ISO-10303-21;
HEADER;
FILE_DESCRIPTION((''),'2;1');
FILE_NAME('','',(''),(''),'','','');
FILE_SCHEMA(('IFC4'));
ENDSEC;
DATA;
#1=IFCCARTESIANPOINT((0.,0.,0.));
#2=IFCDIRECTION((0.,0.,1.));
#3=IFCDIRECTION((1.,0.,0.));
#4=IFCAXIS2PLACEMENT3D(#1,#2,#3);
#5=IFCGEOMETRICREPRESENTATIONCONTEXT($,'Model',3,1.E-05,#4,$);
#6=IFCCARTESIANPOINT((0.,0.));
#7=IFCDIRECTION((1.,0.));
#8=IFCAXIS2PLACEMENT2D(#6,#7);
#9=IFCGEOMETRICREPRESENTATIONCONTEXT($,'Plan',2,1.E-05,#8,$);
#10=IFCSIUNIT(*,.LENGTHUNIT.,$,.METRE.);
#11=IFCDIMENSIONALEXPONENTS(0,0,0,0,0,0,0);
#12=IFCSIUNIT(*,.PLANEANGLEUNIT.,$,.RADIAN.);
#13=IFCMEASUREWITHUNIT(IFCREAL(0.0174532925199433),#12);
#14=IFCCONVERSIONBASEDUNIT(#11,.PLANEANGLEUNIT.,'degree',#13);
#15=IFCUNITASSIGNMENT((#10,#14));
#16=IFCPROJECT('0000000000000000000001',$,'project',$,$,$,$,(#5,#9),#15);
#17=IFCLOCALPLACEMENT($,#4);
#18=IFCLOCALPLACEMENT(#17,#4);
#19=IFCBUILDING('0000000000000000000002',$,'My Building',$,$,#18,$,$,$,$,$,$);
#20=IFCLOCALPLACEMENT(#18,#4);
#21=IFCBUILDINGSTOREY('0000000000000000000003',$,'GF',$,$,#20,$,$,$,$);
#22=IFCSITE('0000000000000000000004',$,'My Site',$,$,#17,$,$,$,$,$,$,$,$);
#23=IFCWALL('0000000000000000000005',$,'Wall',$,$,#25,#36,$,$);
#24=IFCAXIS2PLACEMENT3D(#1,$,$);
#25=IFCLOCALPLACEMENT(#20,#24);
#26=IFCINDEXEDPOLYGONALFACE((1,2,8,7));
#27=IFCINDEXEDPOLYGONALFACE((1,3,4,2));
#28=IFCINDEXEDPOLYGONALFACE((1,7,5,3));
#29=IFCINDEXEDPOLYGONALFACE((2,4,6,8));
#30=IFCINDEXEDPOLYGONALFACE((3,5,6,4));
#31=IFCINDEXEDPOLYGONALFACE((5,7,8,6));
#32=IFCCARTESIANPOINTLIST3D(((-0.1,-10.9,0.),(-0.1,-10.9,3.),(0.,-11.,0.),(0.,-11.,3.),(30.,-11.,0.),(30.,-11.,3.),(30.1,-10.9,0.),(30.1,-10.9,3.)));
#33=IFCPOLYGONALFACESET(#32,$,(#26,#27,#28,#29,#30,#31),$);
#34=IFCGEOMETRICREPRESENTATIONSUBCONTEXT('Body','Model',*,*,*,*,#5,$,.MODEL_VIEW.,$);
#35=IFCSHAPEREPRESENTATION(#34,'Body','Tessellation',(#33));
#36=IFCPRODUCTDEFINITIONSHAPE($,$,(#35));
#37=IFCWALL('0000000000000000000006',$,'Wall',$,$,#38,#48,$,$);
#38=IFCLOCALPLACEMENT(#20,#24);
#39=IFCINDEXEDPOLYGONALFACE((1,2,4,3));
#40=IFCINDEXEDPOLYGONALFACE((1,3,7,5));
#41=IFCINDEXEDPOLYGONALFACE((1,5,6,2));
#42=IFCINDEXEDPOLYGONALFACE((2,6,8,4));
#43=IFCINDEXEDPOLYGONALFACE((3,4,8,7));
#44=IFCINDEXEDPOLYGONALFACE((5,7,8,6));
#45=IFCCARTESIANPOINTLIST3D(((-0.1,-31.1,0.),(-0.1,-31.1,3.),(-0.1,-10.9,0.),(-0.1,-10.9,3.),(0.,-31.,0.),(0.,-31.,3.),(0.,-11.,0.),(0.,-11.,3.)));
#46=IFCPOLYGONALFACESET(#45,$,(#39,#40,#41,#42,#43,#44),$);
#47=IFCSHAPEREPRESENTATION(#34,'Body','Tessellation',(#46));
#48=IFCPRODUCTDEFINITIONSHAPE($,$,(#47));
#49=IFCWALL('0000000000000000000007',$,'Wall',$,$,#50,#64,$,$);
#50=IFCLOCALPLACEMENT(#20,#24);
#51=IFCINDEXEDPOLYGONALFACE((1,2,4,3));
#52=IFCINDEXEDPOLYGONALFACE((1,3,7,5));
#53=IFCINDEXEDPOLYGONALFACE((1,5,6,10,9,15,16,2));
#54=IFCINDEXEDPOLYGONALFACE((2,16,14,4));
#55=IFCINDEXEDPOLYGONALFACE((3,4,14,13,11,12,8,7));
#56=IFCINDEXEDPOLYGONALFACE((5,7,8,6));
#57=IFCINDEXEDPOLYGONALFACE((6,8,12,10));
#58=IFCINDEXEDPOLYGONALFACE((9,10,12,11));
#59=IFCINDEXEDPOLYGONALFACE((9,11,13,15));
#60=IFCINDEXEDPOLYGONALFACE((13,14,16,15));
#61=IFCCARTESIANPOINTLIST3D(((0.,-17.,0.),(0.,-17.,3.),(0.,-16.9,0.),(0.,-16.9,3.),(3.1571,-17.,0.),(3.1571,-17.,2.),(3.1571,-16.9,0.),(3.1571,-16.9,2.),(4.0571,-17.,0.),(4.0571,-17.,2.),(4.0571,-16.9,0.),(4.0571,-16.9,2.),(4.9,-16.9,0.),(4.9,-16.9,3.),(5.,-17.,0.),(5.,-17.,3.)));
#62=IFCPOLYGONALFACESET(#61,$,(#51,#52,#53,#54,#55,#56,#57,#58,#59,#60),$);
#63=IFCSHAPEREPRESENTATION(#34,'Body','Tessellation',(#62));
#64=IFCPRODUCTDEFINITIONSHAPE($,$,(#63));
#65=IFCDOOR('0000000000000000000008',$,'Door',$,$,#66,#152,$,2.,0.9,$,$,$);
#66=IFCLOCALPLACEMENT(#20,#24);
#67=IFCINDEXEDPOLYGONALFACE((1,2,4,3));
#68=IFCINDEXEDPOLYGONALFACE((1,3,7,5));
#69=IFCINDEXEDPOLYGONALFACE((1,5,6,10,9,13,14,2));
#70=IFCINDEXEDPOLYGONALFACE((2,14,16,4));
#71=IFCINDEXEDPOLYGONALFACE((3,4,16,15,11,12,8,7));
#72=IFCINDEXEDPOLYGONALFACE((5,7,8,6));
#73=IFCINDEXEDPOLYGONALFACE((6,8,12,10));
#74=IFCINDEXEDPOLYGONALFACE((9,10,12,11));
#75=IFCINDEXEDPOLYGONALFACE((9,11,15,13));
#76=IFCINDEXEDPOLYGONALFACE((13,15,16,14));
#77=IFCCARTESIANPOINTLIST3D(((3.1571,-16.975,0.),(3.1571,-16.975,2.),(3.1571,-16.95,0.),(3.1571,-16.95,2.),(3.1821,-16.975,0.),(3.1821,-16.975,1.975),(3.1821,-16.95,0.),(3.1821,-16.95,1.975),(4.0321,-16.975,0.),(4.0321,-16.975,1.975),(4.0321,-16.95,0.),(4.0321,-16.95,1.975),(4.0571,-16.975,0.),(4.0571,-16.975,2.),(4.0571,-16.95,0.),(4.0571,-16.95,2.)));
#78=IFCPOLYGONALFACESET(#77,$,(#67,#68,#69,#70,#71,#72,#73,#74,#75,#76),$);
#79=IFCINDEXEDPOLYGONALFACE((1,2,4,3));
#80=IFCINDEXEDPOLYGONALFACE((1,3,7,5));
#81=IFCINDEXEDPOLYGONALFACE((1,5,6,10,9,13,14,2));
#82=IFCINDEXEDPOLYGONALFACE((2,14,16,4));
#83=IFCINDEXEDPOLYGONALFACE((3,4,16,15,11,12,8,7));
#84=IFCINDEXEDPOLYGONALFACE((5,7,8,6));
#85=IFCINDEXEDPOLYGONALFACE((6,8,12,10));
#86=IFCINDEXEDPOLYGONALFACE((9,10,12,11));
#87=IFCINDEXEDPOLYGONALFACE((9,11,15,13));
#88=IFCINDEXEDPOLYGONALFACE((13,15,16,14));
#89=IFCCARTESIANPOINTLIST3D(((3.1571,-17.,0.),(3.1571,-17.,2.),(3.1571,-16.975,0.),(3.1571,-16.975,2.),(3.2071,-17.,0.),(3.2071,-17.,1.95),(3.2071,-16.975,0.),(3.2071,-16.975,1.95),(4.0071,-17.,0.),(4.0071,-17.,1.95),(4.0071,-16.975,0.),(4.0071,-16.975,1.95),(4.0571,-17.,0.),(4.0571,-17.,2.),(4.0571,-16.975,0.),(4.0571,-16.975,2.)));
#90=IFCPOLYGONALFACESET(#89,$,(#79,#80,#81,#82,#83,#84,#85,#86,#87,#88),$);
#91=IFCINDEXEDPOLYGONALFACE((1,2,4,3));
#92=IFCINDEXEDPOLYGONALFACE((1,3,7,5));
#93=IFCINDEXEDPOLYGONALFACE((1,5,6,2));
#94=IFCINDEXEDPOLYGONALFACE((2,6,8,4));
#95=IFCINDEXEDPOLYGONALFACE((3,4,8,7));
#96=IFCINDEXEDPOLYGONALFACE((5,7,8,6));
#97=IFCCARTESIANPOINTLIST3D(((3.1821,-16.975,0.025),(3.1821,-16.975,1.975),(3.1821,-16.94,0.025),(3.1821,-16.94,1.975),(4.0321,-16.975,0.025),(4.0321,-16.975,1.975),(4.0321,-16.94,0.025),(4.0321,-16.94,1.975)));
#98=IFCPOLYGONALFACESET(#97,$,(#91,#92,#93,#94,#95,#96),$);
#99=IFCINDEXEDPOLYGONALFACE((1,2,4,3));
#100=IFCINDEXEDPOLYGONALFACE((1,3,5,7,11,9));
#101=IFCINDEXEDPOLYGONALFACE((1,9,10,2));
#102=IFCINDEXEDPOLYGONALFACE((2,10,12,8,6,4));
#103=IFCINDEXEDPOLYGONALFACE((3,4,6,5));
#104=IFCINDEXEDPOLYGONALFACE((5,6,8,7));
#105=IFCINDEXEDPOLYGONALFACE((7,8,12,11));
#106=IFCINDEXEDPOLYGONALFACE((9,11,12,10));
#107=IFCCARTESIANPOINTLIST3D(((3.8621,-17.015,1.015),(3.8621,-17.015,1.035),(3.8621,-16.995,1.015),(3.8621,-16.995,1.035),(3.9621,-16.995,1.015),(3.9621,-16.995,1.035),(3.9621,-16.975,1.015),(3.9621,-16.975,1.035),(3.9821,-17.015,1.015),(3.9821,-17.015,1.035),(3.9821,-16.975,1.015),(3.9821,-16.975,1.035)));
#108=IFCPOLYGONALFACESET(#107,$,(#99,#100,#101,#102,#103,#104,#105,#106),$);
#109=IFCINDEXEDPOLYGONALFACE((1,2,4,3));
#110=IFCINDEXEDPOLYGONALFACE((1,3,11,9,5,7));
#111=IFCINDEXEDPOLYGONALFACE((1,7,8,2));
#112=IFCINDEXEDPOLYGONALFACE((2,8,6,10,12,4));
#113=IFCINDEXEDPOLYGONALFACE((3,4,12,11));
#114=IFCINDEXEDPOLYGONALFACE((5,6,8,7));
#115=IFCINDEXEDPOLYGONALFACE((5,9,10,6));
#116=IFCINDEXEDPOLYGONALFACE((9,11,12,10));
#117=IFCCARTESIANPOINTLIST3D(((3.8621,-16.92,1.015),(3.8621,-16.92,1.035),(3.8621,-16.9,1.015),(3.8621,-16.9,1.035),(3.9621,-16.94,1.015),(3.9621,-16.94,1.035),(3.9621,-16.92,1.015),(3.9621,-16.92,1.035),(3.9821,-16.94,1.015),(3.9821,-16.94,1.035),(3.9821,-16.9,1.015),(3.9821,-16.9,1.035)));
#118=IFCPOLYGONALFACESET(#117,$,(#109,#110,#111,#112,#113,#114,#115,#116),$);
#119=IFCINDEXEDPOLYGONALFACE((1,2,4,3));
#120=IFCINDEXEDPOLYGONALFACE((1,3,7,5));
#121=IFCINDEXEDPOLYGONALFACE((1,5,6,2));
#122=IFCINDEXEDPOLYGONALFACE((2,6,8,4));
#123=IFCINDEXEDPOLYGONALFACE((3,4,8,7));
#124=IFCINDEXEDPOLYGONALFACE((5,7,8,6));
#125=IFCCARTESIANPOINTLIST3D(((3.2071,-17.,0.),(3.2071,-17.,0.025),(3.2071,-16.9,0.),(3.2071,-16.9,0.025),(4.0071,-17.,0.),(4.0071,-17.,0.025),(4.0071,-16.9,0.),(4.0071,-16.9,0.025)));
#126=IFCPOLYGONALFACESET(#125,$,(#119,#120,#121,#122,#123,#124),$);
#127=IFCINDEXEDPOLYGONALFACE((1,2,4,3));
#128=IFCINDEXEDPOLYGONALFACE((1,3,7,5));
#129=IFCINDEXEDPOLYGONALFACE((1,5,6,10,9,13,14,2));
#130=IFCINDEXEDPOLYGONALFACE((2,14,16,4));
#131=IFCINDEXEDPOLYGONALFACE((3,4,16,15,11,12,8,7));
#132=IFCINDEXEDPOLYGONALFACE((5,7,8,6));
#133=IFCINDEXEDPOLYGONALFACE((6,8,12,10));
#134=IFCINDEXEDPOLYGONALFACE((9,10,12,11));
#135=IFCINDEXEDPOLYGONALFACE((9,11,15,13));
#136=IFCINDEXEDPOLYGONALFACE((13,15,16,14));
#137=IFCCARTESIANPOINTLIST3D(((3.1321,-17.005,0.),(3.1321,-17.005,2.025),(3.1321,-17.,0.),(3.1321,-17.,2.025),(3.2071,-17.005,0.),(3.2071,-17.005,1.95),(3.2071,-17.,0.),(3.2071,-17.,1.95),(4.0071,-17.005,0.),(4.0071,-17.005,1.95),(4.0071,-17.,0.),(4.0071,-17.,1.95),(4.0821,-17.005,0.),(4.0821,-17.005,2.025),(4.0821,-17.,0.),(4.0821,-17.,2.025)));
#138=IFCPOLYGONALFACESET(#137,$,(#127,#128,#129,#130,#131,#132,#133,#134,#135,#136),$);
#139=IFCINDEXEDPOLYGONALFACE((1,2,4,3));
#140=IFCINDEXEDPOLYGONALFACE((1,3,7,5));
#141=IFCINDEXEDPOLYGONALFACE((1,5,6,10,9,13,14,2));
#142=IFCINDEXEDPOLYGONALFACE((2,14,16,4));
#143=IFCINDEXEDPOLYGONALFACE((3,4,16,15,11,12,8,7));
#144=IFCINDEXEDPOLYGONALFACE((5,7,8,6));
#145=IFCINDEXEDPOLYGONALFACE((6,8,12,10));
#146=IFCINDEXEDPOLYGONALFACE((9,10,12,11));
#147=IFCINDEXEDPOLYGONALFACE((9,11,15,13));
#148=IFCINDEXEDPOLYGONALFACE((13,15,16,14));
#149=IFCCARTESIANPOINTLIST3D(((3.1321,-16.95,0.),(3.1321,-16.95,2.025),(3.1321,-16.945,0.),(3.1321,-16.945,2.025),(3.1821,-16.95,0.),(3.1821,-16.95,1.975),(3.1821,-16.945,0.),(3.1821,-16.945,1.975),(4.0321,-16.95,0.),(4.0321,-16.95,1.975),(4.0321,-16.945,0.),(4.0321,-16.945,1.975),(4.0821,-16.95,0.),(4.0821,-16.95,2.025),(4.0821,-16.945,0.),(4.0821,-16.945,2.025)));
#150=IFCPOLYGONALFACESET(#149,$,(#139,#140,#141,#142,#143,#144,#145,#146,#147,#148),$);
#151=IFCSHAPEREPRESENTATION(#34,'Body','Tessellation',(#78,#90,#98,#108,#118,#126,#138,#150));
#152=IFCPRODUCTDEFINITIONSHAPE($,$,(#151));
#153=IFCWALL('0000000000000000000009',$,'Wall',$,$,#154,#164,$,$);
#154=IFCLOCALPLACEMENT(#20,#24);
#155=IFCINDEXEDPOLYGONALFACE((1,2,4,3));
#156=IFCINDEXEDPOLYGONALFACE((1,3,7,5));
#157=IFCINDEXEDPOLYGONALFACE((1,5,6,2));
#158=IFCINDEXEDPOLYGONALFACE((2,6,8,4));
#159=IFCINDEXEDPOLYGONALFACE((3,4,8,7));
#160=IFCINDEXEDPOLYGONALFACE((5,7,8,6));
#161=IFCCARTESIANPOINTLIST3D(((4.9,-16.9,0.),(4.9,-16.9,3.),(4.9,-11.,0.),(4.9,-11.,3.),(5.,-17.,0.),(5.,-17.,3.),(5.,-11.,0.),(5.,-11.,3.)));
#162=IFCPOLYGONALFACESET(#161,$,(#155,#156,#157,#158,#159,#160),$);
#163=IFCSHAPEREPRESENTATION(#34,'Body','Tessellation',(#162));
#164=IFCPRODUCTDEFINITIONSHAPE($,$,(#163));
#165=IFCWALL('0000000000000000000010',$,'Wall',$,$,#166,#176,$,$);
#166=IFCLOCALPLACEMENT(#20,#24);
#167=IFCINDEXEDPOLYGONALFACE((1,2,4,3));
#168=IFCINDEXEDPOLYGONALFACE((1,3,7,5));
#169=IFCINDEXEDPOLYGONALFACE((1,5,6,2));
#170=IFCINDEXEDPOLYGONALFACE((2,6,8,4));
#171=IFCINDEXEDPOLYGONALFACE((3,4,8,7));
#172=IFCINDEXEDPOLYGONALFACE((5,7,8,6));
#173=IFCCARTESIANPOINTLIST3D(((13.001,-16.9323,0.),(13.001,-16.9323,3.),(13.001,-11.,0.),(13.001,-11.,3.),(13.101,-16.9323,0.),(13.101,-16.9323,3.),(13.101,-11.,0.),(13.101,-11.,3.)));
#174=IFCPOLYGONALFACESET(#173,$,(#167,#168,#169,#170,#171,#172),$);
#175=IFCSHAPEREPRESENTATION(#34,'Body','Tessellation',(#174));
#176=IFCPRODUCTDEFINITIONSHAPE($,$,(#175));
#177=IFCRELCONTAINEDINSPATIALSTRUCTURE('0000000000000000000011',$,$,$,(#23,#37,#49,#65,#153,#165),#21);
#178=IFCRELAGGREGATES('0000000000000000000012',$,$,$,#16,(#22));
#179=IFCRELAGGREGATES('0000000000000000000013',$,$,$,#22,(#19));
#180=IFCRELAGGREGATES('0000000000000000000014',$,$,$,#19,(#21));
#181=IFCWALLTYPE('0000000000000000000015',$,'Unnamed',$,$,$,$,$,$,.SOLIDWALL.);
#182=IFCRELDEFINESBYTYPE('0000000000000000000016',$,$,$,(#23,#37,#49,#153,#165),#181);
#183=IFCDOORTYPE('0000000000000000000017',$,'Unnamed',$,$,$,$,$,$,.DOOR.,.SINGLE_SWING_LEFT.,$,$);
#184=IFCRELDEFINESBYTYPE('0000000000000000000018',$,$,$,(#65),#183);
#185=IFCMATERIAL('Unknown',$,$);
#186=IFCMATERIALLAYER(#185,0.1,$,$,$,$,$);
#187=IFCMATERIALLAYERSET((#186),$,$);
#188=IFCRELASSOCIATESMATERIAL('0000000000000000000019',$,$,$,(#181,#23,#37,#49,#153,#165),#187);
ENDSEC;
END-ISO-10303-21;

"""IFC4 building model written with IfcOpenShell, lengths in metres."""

from ifc_helpers import new_model, entity, si_unit, converted_unit, frame, origin_with_axes, origin_2d_with_axis, place, context, subcontext, project, spatial, line, indexed_curve, outline, extrude, shape, source, transform, mapped, material, layer, layer_set, layer_usage, type_object, type_shapes, element, fill, save


model = new_model("IFC4")

# Units and contexts
model_context = context("Model", 3, precision=1e-05, world=origin_with_axes())
plan_context = context("Plan", 2, precision=1e-05, world=origin_2d_with_axis())
body_context_1 = subcontext(model_context, "Body", "Model", "MODEL_VIEW")
body_context_2 = subcontext(plan_context, "Body", "Plan", "PLAN_VIEW")
ifc_project = project(units=[si_unit("LENGTHUNIT", "METRE"), converted_unit("PLANEANGLEUNIT", "degree", entity("IfcReal", 0.0174532925199433), si_unit("PLANEANGLEUNIT", "RADIAN"), dimensions=[0, 0, 0, 0, 0, 0, 0])], contexts=[model_context, plan_context])

# Site, building, storey
site_placement = place(None, origin_with_axes())
site = spatial("IfcSite", under=ifc_project, at=site_placement, Name="My Site")
building_placement = place(site_placement, origin_with_axes())
building = spatial("IfcBuilding", under=site, at=building_placement, Name="My Building")
storey_placement = place(building_placement, origin_with_axes())
storey = spatial("IfcBuildingStorey", under=building, at=storey_placement, Name="GF")

# Shared definitions
ifc_material = material(Name="Unknown")

# Walls
ifc_layer_1 = layer(ifc_material, 0.1)
ifc_layer_set_1 = layer_set([ifc_layer_1])
ifc_layer_usage_1 = layer_usage(ifc_layer_set_1, "AXIS2", "POSITIVE", 0.0)
wall_type = type_object("IfcWallType", Name="Unnamed", PredefinedType="SOLIDWALL", material=ifc_layer_set_1)
wall_1_placement = place(storey_placement, frame((0.0, -11.0, 0.0), z_axis=(0.0, 0.0, 1.0), x_axis=(1.0, 0.0, 0.0)))
element("IfcWall", 1, at=wall_1_placement, inside=storey, type_object=wall_type, material=ifc_layer_usage_1, Name="Wall", context=body_context_1, shape_type="SweptSolid", body=[
    extrude(outline(indexed_curve([(0.0, 0.0), (-0.1, 0.1), (30.1, 0.1), (30.0, 0.0)], segments=[line(1, 2, 3, 4, 1)])), origin_with_axes(), (0.0, 0.0, 1.0), 3.0),
])
ifc_layer_usage_2 = layer_usage(ifc_layer_set_1, "AXIS2", "POSITIVE", 0.0)
wall_2_placement = place(storey_placement, frame((0.0, -31.0, 0.0), z_axis=(0.0, 0.0, 1.0), x_axis=(0.0, 1.0, 0.0)))
element("IfcWall", 2, at=wall_2_placement, inside=storey, type_object=wall_type, material=ifc_layer_usage_2, Name="Wall", context=body_context_1, shape_type="SweptSolid", body=[
    extrude(outline(indexed_curve([(0.0, 0.0), (-0.1, 0.1), (20.1, 0.1), (20.0, 0.0)], segments=[line(1, 2, 3, 4, 1)])), origin_with_axes(), (0.0, 0.0, 1.0), 3.0),
])

# Wall, opening, door
ifc_layer_usage_3 = layer_usage(ifc_layer_set_1, "AXIS2", "POSITIVE", 0.0)
wall_3_placement = place(storey_placement, frame((0.0, -17.0, 0.0), z_axis=(0.0, 0.0, 1.0), x_axis=(1.0, 0.0, 0.0)))
wall_3 = element("IfcWall", 3, at=wall_3_placement, inside=storey, type_object=wall_type, material=ifc_layer_usage_3, Name="Wall", context=body_context_1, shape_type="SweptSolid", body=[
    extrude(outline(indexed_curve([(0.0, 0.0), (0.0, 0.1), (4.9, 0.1), (5.0, 0.0)], segments=[line(1, 2, 3, 4, 1)])), origin_with_axes(), (0.0, 0.0, 1.0), 3.0),
])
shared_shape_1 = source(origin_with_axes(), body_context_1, "Body", "SweptSolid", [
    extrude(outline(indexed_curve([(0.0, 0.0), (0.9, 0.0), (0.9, 2.0), (0.0, 2.0)], segments=[line(1, 2, 3, 4, 1)])), frame((0.0, -0.6, 0.0), z_axis=(0.0, -1.0, 0.0), x_axis=(1.0, 0.0, 0.0)), (0.0, 0.0, -1.0), 1.2),
])
opening_1_placement = place(wall_3_placement, frame((3.1571, 0.0, 0.0), z_axis=(0.0, 0.0, 1.0), x_axis=(1.0, 0.0, 0.0)))
opening_1 = element("IfcOpeningElement", 4, at=opening_1_placement, cuts=wall_3, PredefinedType="OPENING", context=body_context_1, shape_type="MappedRepresentation", body=[
    mapped(shared_shape_1, transform((0.0, 0.0, 0.0), x_axis=(1.0, 0.0, 0.0), y_axis=(0.0, 1.0, 0.0), z_axis=(0.0, 0.0, 1.0), scale=1.0)),
])
door_type = type_object("IfcDoorType", Name="Unnamed", OperationType="SINGLE_SWING_LEFT", PredefinedType="DOOR")
shared_shape_2 = source(origin_with_axes(), body_context_1, "Body", "SweptSolid", [
    extrude(outline(indexed_curve([(0.0, 0.0), (0.0, 2.0), (0.9, 2.0), (0.9, 0.0), (0.875, 0.0), (0.875, 1.975), (0.025, 1.975), (0.025, 0.0)], segments=[line(1, 2, 3, 4, 5, 6, 7, 8, 1)])), frame((0.0, 0.025, 0.0), z_axis=(0.0, -1.0, 0.0), x_axis=(1.0, 0.0, 0.0)), (0.0, 0.0, -1.0), 0.025),
    extrude(outline(indexed_curve([(0.0, 0.0), (0.0, 2.0), (0.9, 2.0), (0.9, 0.0), (0.85, 0.0), (0.85, 1.95), (0.05, 1.95), (0.05, 0.0)], segments=[line(1, 2, 3, 4, 5, 6, 7, 8, 1)])), frame((0.0, 0.0, 0.0), z_axis=(0.0, -1.0, 0.0), x_axis=(1.0, 0.0, 0.0)), (0.0, 0.0, -1.0), 0.025),
    extrude(outline(indexed_curve([(0.0, 0.0), (0.85, 0.0), (0.85, 0.035), (0.0, 0.035)], segments=[line(1, 2, 3, 4, 1)])), frame((0.025, 0.025, 0.025), z_axis=(0.0, 0.0, 1.0), x_axis=(1.0, 0.0, 0.0)), (0.0, 0.0, 1.0), 1.95),
    extrude(outline(indexed_curve([(0.0, 0.0), (0.0, -0.04), (-0.12, -0.04), (-0.12, -0.02), (-0.02, -0.02), (-0.02, 0.0)], segments=[line(1, 2, 3, 4, 5, 6, 1)])), frame((0.825, 0.025, 1.015), z_axis=(0.0, 0.0, 1.0), x_axis=(1.0, 0.0, 0.0)), (0.0, 0.0, 1.0), 0.02),
    extrude(outline(indexed_curve([(0.0, 0.0), (0.0, 0.04), (-0.12, 0.04), (-0.12, 0.02), (-0.02, 0.02), (-0.02, 0.0)], segments=[line(1, 2, 3, 4, 5, 6, 1)])), frame((0.825, 0.06, 1.015), z_axis=(0.0, 0.0, 1.0), x_axis=(1.0, 0.0, 0.0)), (0.0, 0.0, 1.0), 0.02),
    extrude(outline(indexed_curve([(0.0, 0.0), (0.8, 0.0), (0.8, 0.1), (0.0, 0.1)], segments=[line(1, 2, 3, 4, 1)])), frame((0.05, 0.0, 0.0), z_axis=(0.0, 0.0, 1.0), x_axis=(1.0, 0.0, 0.0)), (0.0, 0.0, 1.0), 0.025),
    extrude(outline(indexed_curve([(0.0, 0.0), (0.0, 2.025), (0.95, 2.025), (0.95, 0.0), (0.875, 0.0), (0.875, 1.95), (0.075, 1.95), (0.075, 0.0)], segments=[line(1, 2, 3, 4, 5, 6, 7, 8, 1)])), frame((-0.025, -0.005, 0.0), z_axis=(0.0, -1.0, 0.0), x_axis=(1.0, 0.0, 0.0)), (0.0, 0.0, -1.0), 0.005),
    extrude(outline(indexed_curve([(0.0, 0.0), (0.0, 2.025), (0.95, 2.025), (0.95, 0.0), (0.9, 0.0), (0.9, 1.975), (0.05, 1.975), (0.05, 0.0)], segments=[line(1, 2, 3, 4, 5, 6, 7, 8, 1)])), frame((-0.025, 0.05, 0.0), z_axis=(0.0, -1.0, 0.0), x_axis=(1.0, 0.0, 0.0)), (0.0, 0.0, -1.0), 0.005),
])
shared_shape_3 = source(origin_with_axes(), body_context_2, "Body", "Curve2D", [
    entity("IfcIndexedPolyCurve", entity("IfcCartesianPointList2D", [[0.0, 0.0], [0.0, 0.05], [0.025, 0.05], [0.025, 0.025], [0.05, 0.025], [0.05, 0.0]]), [entity("IfcLineIndex", [1, 2, 3, 4, 5, 6, 1])]),
    entity("IfcIndexedPolyCurve", entity("IfcCartesianPointList2D", [[0.9, 0.0], [0.9, 0.05], [0.875, 0.05], [0.875, 0.025], [0.85, 0.025], [0.85, 0.0]]), [entity("IfcLineIndex", [1, 2, 3, 4, 5, 6, 1])]),
    entity("IfcTrimmedCurve", entity("IfcEllipse", entity("IfcAxis2Placement2D", entity("IfcCartesianPoint", [0.06, 0.05]), entity("IfcDirection", [1.0, 0.0])), 0.815, 0.85), [entity("IfcCartesianPoint", [0.875, 0.05])], [entity("IfcCartesianPoint", [0.06, 0.9])], True, "CARTESIAN"),
    entity("IfcIndexedPolyCurve", entity("IfcCartesianPointList2D", [[0.025, 0.05], [0.06, 0.05], [0.06, 0.9], [0.025, 0.9]]), [entity("IfcLineIndex", [1, 2, 3, 4, 1])]),
])
type_shapes(door_type, [shared_shape_2, shared_shape_3])
door_1_placement = place(opening_1_placement, origin_with_axes())
door_1 = element("IfcDoor", 5, at=door_1_placement, inside=storey, type_object=door_type, Name="Door", OverallHeight=2.0, OverallWidth=0.9, shapes=[
    shape(body_context_1, "Body", "MappedRepresentation", [mapped(shared_shape_2, transform((0.0, 0.0, 0.0), x_axis=(1.0, 0.0, 0.0), y_axis=(0.0, 1.0, 0.0), z_axis=(0.0, 0.0, 1.0), scale=1.0))]),
    shape(body_context_2, "Body", "MappedRepresentation", [mapped(shared_shape_3, transform((0.0, 0.0, 0.0), x_axis=(1.0, 0.0, 0.0), y_axis=(0.0, 1.0, 0.0), z_axis=(0.0, 0.0, 1.0), scale=1.0))]),
])
fill(opening_1, door_1)

# Wall
ifc_layer_usage_4 = layer_usage(ifc_layer_set_1, "AXIS2", "POSITIVE", 0.0)
wall_4_placement = place(storey_placement, frame((5.0, -17.0, 0.0), z_axis=(0.0, 0.0, 1.0), x_axis=(0.0, 1.0, 0.0)))
element("IfcWall", 6, at=wall_4_placement, inside=storey, type_object=wall_type, material=ifc_layer_usage_4, Name="Wall", context=body_context_1, shape_type="SweptSolid", body=[
    extrude(outline(indexed_curve([(0.0, 0.0), (0.1, 0.1), (6.0, 0.1), (6.0, 0.0)], segments=[line(1, 2, 3, 4, 1)])), origin_with_axes(), (0.0, 0.0, 1.0), 3.0),
])

# Wall
ifc_layer_usage_5 = layer_usage(ifc_layer_set_1, "AXIS2", "POSITIVE", 0.0)
wall_5_placement = place(storey_placement, frame((13.101, -16.9323, 0.0), z_axis=(0.0, 0.0, 1.0), x_axis=(0.0, 1.0, 0.0)))
element("IfcWall", 7, at=wall_5_placement, inside=storey, type_object=wall_type, material=ifc_layer_usage_5, Name="Wall", context=body_context_1, shape_type="SweptSolid", body=[
    extrude(outline(indexed_curve([(0.0, 0.0), (0.0, 0.1), (5.9323, 0.1), (5.9323, 0.0)], segments=[line(1, 2, 3, 4, 1)])), origin_with_axes(), (0.0, 0.0, 1.0), 3.0),
])

save(model, "model.ifc")
